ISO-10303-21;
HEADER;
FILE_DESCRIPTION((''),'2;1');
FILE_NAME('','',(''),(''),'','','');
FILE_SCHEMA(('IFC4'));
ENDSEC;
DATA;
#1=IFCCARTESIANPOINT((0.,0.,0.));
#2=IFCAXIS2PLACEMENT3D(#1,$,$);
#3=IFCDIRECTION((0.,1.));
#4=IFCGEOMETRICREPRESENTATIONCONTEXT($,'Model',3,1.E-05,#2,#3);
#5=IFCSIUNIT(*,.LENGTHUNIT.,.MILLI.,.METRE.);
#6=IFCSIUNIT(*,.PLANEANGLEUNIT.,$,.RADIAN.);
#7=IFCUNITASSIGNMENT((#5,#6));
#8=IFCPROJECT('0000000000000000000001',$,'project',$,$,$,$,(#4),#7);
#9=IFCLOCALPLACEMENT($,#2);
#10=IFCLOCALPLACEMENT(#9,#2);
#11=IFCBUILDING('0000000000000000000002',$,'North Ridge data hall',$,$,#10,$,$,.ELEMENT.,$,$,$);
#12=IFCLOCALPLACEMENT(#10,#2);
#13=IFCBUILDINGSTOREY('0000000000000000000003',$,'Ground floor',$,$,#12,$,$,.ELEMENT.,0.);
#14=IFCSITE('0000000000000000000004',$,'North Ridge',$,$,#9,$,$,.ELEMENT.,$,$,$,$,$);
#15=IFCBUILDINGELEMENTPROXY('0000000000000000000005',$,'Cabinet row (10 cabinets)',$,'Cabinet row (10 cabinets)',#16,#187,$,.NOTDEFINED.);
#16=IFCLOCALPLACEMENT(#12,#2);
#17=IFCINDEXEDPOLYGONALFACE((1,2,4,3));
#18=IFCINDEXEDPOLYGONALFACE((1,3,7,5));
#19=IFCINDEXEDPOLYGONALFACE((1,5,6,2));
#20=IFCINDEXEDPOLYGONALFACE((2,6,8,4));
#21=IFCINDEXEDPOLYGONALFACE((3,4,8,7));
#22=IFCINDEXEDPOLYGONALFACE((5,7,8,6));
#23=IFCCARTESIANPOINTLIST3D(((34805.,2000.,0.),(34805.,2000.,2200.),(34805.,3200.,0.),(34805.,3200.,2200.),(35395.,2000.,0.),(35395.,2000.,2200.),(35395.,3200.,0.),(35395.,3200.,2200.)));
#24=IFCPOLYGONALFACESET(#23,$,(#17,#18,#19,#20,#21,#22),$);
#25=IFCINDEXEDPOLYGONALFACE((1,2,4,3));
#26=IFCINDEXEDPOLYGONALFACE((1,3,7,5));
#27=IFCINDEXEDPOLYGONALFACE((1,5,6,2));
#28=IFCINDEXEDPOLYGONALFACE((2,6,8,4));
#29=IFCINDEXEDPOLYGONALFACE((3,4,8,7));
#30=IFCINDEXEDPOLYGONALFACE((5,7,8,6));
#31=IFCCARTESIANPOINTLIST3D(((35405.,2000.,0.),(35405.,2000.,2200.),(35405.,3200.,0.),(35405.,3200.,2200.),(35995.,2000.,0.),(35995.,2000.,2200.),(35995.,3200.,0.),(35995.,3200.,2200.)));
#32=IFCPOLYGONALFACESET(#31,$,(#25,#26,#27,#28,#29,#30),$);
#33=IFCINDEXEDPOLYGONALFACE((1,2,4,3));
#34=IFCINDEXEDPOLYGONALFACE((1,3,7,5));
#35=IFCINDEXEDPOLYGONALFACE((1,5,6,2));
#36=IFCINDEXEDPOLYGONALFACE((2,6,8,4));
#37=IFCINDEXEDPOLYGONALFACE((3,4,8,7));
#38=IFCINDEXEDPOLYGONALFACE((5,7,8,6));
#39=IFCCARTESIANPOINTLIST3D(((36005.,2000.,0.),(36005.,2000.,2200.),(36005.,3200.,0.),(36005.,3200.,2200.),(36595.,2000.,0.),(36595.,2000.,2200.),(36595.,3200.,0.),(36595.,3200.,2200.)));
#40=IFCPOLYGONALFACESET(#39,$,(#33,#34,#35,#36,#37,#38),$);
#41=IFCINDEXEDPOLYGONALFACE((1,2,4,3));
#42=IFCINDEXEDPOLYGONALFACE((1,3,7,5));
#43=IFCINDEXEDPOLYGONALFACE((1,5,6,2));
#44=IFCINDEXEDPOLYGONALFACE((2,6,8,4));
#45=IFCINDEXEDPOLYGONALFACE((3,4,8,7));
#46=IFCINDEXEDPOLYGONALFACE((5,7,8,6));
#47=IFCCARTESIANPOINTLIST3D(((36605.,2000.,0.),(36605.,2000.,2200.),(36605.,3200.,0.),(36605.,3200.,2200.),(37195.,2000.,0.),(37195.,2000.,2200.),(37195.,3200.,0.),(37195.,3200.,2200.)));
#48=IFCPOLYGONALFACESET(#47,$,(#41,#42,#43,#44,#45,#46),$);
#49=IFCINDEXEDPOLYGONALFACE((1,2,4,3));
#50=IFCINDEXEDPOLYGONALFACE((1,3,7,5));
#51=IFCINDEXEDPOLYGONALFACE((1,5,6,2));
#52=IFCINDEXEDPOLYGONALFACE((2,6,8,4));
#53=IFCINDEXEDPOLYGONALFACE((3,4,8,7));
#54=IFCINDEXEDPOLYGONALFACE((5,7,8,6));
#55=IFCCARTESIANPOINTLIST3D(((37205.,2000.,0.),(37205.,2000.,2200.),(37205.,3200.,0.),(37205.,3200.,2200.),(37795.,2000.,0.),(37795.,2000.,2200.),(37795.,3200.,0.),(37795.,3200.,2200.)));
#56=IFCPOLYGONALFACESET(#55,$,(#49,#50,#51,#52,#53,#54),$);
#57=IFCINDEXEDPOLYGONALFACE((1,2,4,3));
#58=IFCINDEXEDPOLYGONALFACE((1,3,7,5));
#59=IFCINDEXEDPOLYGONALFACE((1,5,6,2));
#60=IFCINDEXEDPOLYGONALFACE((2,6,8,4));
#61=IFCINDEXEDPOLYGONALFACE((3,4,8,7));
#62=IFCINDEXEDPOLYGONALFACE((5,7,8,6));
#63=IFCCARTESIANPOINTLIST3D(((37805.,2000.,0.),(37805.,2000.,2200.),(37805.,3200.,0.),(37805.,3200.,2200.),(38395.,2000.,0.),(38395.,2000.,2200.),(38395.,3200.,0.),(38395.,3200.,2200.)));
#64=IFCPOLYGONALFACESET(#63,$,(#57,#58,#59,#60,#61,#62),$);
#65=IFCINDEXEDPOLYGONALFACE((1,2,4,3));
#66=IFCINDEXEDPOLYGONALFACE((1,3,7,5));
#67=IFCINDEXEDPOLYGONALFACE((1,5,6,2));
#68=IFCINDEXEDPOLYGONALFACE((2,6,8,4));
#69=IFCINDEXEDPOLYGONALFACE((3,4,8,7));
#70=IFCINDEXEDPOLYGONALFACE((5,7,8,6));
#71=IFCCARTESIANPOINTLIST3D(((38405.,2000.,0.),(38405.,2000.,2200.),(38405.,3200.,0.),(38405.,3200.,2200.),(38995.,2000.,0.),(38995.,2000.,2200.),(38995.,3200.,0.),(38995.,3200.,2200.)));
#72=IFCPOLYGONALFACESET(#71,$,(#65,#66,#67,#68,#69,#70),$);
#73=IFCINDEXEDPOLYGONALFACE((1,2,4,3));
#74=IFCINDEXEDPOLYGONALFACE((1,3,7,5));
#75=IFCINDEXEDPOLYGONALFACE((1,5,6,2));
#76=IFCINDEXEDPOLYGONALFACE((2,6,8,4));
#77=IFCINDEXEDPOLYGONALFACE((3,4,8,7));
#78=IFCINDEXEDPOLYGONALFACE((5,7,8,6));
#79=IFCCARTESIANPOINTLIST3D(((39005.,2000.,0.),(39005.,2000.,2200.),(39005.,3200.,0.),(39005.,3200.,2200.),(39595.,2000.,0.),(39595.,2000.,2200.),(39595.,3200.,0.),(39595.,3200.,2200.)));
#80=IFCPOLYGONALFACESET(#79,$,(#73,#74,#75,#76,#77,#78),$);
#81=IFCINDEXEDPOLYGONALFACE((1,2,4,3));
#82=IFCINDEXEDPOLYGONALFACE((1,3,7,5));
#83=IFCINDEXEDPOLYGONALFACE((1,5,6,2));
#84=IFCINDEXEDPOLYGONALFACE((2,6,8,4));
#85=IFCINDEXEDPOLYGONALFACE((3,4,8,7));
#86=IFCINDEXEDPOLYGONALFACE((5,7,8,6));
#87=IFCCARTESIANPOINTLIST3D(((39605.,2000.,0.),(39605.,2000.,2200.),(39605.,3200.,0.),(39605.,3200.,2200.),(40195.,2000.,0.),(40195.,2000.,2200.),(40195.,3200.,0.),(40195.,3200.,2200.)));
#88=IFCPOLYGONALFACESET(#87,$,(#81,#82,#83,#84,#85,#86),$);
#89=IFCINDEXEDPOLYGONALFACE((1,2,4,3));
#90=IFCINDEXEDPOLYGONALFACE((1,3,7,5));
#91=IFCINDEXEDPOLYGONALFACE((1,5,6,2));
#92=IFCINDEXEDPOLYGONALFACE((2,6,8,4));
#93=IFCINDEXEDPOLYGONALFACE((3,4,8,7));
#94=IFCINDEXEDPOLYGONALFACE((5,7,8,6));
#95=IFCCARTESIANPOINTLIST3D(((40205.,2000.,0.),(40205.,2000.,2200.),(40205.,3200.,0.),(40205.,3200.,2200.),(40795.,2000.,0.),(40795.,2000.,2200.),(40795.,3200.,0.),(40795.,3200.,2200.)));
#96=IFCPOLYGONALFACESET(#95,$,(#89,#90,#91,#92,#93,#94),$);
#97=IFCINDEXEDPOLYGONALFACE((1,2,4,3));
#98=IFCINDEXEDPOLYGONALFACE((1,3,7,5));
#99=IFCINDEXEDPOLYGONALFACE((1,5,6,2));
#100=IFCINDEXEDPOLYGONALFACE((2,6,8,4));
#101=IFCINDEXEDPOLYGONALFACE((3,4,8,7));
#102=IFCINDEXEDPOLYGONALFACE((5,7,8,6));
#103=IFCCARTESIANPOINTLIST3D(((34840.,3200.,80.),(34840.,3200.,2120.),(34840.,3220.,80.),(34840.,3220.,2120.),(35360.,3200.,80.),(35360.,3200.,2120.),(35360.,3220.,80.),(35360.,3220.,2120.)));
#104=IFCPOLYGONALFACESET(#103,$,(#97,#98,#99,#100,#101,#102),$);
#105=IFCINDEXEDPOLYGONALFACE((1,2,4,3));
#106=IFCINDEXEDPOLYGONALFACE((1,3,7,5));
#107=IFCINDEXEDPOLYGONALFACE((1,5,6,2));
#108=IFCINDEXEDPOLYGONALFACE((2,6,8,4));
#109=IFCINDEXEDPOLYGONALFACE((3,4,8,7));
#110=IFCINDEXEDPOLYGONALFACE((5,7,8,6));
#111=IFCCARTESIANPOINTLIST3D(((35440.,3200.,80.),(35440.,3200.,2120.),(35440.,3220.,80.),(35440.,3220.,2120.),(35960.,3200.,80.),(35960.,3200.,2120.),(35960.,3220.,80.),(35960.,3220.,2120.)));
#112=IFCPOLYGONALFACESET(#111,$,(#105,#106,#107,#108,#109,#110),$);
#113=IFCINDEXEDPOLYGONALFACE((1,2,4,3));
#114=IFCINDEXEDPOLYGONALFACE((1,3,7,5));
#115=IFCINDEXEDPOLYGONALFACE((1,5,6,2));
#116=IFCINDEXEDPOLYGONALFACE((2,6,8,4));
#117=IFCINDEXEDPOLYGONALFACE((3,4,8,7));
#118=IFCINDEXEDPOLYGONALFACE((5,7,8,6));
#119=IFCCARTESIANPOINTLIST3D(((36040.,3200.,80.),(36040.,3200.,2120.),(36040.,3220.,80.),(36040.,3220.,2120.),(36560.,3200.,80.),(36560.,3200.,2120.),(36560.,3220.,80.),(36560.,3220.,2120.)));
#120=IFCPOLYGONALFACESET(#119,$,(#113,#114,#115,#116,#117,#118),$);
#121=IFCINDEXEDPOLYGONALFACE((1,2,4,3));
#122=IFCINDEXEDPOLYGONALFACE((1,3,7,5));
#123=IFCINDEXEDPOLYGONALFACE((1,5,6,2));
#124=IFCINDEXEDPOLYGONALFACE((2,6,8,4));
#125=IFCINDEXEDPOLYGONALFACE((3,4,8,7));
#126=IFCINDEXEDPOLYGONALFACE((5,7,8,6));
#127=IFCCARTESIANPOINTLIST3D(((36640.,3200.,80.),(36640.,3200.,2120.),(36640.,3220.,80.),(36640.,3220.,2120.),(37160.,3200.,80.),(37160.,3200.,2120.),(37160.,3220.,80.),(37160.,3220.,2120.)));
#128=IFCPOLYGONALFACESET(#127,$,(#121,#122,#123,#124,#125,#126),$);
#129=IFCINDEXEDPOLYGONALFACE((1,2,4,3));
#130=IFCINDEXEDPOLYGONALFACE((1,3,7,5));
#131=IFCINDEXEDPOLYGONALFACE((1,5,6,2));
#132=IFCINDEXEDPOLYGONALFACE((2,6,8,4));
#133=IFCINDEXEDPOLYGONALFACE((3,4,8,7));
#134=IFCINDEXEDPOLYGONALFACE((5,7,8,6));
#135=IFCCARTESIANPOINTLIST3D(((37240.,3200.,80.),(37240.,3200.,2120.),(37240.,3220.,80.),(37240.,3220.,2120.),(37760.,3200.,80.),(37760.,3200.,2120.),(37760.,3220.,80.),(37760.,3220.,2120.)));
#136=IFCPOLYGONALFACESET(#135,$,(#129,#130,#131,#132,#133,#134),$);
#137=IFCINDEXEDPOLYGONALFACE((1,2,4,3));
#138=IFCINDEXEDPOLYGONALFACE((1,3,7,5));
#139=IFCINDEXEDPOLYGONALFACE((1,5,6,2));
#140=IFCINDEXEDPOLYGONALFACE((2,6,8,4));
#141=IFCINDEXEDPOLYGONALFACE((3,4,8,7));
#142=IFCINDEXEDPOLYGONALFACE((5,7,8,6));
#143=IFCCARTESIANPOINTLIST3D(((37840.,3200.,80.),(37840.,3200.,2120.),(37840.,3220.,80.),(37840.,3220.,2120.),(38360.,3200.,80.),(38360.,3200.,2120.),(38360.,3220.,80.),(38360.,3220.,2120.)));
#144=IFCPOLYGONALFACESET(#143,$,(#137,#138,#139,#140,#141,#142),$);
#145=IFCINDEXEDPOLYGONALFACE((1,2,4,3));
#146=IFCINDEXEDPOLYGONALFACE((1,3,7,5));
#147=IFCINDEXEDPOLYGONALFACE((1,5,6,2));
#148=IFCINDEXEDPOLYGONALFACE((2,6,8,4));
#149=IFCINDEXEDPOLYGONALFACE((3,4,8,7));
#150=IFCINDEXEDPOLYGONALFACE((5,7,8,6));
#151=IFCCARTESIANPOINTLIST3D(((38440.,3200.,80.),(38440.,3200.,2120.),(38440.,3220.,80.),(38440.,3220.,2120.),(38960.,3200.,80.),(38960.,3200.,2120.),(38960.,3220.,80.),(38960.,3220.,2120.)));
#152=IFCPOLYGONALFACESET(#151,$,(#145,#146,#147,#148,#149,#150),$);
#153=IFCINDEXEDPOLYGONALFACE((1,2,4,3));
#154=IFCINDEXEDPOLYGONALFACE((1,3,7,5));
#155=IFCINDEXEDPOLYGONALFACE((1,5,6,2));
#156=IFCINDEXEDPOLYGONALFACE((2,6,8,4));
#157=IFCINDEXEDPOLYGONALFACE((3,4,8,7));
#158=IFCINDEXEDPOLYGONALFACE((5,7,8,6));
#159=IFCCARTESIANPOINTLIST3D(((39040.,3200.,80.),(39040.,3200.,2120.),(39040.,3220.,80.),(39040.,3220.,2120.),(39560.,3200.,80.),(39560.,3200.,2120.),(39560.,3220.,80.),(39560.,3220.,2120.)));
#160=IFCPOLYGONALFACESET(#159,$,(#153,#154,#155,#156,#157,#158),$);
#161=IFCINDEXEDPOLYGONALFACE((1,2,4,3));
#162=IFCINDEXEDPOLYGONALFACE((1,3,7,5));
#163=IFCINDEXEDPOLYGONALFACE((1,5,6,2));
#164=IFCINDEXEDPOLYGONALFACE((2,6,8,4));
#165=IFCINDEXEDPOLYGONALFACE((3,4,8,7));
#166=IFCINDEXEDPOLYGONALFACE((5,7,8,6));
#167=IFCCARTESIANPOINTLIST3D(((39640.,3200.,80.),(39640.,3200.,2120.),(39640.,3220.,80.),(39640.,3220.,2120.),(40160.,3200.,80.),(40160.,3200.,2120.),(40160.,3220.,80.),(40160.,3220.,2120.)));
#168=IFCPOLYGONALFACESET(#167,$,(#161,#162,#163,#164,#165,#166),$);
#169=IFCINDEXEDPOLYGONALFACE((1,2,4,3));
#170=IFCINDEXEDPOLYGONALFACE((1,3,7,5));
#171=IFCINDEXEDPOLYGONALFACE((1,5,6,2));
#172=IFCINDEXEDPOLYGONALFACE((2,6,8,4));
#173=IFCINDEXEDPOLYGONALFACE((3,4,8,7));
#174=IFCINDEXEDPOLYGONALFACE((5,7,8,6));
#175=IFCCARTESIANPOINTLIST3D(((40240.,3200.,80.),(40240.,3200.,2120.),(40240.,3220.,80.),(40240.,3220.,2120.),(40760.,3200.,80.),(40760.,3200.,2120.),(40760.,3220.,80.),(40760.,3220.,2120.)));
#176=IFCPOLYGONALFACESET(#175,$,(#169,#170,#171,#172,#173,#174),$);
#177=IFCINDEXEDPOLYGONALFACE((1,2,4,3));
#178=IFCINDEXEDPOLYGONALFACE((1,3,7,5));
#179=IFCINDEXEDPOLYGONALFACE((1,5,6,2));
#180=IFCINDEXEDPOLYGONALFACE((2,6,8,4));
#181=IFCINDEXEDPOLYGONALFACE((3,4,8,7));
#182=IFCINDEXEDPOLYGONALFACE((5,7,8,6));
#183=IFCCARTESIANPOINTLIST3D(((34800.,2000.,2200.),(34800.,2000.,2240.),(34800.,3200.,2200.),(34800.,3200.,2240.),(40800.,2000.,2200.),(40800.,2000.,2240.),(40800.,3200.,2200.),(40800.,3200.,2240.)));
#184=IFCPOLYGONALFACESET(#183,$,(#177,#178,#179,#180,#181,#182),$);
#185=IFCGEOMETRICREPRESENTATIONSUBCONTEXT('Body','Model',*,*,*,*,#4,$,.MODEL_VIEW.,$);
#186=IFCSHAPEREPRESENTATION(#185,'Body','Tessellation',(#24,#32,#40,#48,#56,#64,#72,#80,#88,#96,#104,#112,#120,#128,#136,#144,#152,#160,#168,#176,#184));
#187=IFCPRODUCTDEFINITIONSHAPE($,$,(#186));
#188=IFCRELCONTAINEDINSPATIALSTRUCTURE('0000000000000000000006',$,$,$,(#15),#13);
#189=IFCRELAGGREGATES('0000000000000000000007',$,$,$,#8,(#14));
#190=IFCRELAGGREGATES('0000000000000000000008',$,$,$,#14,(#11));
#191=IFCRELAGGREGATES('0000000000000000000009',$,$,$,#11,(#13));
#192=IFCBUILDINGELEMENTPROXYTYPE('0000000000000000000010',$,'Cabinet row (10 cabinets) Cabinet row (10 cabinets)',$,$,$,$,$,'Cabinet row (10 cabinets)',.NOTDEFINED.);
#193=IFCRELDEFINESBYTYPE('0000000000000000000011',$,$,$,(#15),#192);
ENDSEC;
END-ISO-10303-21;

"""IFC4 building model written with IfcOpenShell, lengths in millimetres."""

from ifc_helpers import new_model, si_unit, direction, frame, origin, place, context, subcontext, project, spatial, polyline, outline, extrude, source, transform, mapped, type_object, type_shapes, element, save


model = new_model("IFC4")

# Units and contexts
model_context = context("Model", 3, precision=1e-05, world=origin(), true_north=direction((0.0, 1.0)))
body_context = subcontext(model_context, "Body", "Model", "MODEL_VIEW")
ifc_project = project(units=[si_unit("LENGTHUNIT", "METRE", prefix="MILLI"), si_unit("PLANEANGLEUNIT", "RADIAN")], contexts=[model_context])

# Site, building, storey
site_placement = place(None, origin())
site = spatial("IfcSite", under=ifc_project, at=site_placement, Name="North Ridge", CompositionType="ELEMENT")
building_placement = place(site_placement, origin())
building = spatial("IfcBuilding", under=site, at=building_placement, Name="North Ridge data hall", CompositionType="ELEMENT")
storey_placement = place(building_placement, origin())
storey = spatial("IfcBuildingStorey", under=building, at=storey_placement, Name="Ground floor", CompositionType="ELEMENT", Elevation=0.0)

# Building element proxy
building_element_proxy_type_1 = type_object("IfcBuildingElementProxyType", Name="Cabinet row (10 cabinets) Cabinet row (10 cabinets)", ElementType="Cabinet row (10 cabinets)", PredefinedType="NOTDEFINED")
shared_shape_1 = source(origin(), body_context, "Body", "SweptSolid", [
    extrude(outline(polyline([(5.0, 0.0), (595.0, 0.0), (595.0, 1200.0), (5.0, 1200.0), (5.0, 0.0)])), origin(), (0.0, 0.0, 1.0), 2200.0),
    extrude(outline(polyline([(605.0, 0.0), (1195.0, 0.0), (1195.0, 1200.0), (605.0, 1200.0), (605.0, 0.0)])), origin(), (0.0, 0.0, 1.0), 2200.0),
    extrude(outline(polyline([(1205.0, 0.0), (1795.0, 0.0), (1795.0, 1200.0), (1205.0, 1200.0), (1205.0, 0.0)])), origin(), (0.0, 0.0, 1.0), 2200.0),
    extrude(outline(polyline([(1805.0, 0.0), (2395.0, 0.0), (2395.0, 1200.0), (1805.0, 1200.0), (1805.0, 0.0)])), origin(), (0.0, 0.0, 1.0), 2200.0),
    extrude(outline(polyline([(2405.0, 0.0), (2995.0, 0.0), (2995.0, 1200.0), (2405.0, 1200.0), (2405.0, 0.0)])), origin(), (0.0, 0.0, 1.0), 2200.0),
    extrude(outline(polyline([(3005.0, 0.0), (3595.0, 0.0), (3595.0, 1200.0), (3005.0, 1200.0), (3005.0, 0.0)])), origin(), (0.0, 0.0, 1.0), 2200.0),
    extrude(outline(polyline([(3605.0, 0.0), (4195.0, 0.0), (4195.0, 1200.0), (3605.0, 1200.0), (3605.0, 0.0)])), origin(), (0.0, 0.0, 1.0), 2200.0),
    extrude(outline(polyline([(4205.0, 0.0), (4795.0, 0.0), (4795.0, 1200.0), (4205.0, 1200.0), (4205.0, 0.0)])), origin(), (0.0, 0.0, 1.0), 2200.0),
    extrude(outline(polyline([(4805.0, 0.0), (5395.0, 0.0), (5395.0, 1200.0), (4805.0, 1200.0), (4805.0, 0.0)])), origin(), (0.0, 0.0, 1.0), 2200.0),
    extrude(outline(polyline([(5405.0, 0.0), (5995.0, 0.0), (5995.0, 1200.0), (5405.0, 1200.0), (5405.0, 0.0)])), origin(), (0.0, 0.0, 1.0), 2200.0),
    extrude(outline(polyline([(40.0, 1200.0), (560.0, 1200.0), (560.0, 1220.0), (40.0, 1220.0), (40.0, 1200.0)])), frame((0.0, 0.0, 80.0)), (0.0, 0.0, 1.0), 2040.0),
    extrude(outline(polyline([(640.0, 1200.0), (1160.0, 1200.0), (1160.0, 1220.0), (640.0, 1220.0), (640.0, 1200.0)])), frame((0.0, 0.0, 80.0)), (0.0, 0.0, 1.0), 2040.0),
    extrude(outline(polyline([(1240.0, 1200.0), (1760.0, 1200.0), (1760.0, 1220.0), (1240.0, 1220.0), (1240.0, 1200.0)])), frame((0.0, 0.0, 80.0)), (0.0, 0.0, 1.0), 2040.0),
    extrude(outline(polyline([(1840.0, 1200.0), (2360.0, 1200.0), (2360.0, 1220.0), (1840.0, 1220.0), (1840.0, 1200.0)])), frame((0.0, 0.0, 80.0)), (0.0, 0.0, 1.0), 2040.0),
    extrude(outline(polyline([(2440.0, 1200.0), (2960.0, 1200.0), (2960.0, 1220.0), (2440.0, 1220.0), (2440.0, 1200.0)])), frame((0.0, 0.0, 80.0)), (0.0, 0.0, 1.0), 2040.0),
    extrude(outline(polyline([(3040.0, 1200.0), (3560.0, 1200.0), (3560.0, 1220.0), (3040.0, 1220.0), (3040.0, 1200.0)])), frame((0.0, 0.0, 80.0)), (0.0, 0.0, 1.0), 2040.0),
    extrude(outline(polyline([(3640.0, 1200.0), (4160.0, 1200.0), (4160.0, 1220.0), (3640.0, 1220.0), (3640.0, 1200.0)])), frame((0.0, 0.0, 80.0)), (0.0, 0.0, 1.0), 2040.0),
    extrude(outline(polyline([(4240.0, 1200.0), (4760.0, 1200.0), (4760.0, 1220.0), (4240.0, 1220.0), (4240.0, 1200.0)])), frame((0.0, 0.0, 80.0)), (0.0, 0.0, 1.0), 2040.0),
    extrude(outline(polyline([(4840.0, 1200.0), (5360.0, 1200.0), (5360.0, 1220.0), (4840.0, 1220.0), (4840.0, 1200.0)])), frame((0.0, 0.0, 80.0)), (0.0, 0.0, 1.0), 2040.0),
    extrude(outline(polyline([(5440.0, 1200.0), (5960.0, 1200.0), (5960.0, 1220.0), (5440.0, 1220.0), (5440.0, 1200.0)])), frame((0.0, 0.0, 80.0)), (0.0, 0.0, 1.0), 2040.0),
    extrude(outline(polyline([(0.0, 0.0), (6000.0, 0.0), (6000.0, 1200.0), (0.0, 1200.0), (0.0, 0.0)])), frame((0.0, 0.0, 2200.0)), (0.0, 0.0, 1.0), 40.0),
])
type_shapes(building_element_proxy_type_1, [shared_shape_1])
for number, where, z_axis, x_axis, name in (
    (1, (34800.0, 2000.0, 0.0), (0.0, 0.0, 1.0), (1.0, 0.0, 0.0), "Cabinet row (10 cabinets)"),
):
    element("IfcBuildingElementProxy", number, at=place(storey_placement, frame(where, z_axis=z_axis, x_axis=x_axis)), inside=storey, type_object=building_element_proxy_type_1, Name=name, ObjectType="Cabinet row (10 cabinets)", PredefinedType="NOTDEFINED", context=body_context, shape_type="MappedRepresentation", body=[
        mapped(shared_shape_1, transform((0.0, 0.0, 0.0))),
    ])

save(model, "model.ifc")
